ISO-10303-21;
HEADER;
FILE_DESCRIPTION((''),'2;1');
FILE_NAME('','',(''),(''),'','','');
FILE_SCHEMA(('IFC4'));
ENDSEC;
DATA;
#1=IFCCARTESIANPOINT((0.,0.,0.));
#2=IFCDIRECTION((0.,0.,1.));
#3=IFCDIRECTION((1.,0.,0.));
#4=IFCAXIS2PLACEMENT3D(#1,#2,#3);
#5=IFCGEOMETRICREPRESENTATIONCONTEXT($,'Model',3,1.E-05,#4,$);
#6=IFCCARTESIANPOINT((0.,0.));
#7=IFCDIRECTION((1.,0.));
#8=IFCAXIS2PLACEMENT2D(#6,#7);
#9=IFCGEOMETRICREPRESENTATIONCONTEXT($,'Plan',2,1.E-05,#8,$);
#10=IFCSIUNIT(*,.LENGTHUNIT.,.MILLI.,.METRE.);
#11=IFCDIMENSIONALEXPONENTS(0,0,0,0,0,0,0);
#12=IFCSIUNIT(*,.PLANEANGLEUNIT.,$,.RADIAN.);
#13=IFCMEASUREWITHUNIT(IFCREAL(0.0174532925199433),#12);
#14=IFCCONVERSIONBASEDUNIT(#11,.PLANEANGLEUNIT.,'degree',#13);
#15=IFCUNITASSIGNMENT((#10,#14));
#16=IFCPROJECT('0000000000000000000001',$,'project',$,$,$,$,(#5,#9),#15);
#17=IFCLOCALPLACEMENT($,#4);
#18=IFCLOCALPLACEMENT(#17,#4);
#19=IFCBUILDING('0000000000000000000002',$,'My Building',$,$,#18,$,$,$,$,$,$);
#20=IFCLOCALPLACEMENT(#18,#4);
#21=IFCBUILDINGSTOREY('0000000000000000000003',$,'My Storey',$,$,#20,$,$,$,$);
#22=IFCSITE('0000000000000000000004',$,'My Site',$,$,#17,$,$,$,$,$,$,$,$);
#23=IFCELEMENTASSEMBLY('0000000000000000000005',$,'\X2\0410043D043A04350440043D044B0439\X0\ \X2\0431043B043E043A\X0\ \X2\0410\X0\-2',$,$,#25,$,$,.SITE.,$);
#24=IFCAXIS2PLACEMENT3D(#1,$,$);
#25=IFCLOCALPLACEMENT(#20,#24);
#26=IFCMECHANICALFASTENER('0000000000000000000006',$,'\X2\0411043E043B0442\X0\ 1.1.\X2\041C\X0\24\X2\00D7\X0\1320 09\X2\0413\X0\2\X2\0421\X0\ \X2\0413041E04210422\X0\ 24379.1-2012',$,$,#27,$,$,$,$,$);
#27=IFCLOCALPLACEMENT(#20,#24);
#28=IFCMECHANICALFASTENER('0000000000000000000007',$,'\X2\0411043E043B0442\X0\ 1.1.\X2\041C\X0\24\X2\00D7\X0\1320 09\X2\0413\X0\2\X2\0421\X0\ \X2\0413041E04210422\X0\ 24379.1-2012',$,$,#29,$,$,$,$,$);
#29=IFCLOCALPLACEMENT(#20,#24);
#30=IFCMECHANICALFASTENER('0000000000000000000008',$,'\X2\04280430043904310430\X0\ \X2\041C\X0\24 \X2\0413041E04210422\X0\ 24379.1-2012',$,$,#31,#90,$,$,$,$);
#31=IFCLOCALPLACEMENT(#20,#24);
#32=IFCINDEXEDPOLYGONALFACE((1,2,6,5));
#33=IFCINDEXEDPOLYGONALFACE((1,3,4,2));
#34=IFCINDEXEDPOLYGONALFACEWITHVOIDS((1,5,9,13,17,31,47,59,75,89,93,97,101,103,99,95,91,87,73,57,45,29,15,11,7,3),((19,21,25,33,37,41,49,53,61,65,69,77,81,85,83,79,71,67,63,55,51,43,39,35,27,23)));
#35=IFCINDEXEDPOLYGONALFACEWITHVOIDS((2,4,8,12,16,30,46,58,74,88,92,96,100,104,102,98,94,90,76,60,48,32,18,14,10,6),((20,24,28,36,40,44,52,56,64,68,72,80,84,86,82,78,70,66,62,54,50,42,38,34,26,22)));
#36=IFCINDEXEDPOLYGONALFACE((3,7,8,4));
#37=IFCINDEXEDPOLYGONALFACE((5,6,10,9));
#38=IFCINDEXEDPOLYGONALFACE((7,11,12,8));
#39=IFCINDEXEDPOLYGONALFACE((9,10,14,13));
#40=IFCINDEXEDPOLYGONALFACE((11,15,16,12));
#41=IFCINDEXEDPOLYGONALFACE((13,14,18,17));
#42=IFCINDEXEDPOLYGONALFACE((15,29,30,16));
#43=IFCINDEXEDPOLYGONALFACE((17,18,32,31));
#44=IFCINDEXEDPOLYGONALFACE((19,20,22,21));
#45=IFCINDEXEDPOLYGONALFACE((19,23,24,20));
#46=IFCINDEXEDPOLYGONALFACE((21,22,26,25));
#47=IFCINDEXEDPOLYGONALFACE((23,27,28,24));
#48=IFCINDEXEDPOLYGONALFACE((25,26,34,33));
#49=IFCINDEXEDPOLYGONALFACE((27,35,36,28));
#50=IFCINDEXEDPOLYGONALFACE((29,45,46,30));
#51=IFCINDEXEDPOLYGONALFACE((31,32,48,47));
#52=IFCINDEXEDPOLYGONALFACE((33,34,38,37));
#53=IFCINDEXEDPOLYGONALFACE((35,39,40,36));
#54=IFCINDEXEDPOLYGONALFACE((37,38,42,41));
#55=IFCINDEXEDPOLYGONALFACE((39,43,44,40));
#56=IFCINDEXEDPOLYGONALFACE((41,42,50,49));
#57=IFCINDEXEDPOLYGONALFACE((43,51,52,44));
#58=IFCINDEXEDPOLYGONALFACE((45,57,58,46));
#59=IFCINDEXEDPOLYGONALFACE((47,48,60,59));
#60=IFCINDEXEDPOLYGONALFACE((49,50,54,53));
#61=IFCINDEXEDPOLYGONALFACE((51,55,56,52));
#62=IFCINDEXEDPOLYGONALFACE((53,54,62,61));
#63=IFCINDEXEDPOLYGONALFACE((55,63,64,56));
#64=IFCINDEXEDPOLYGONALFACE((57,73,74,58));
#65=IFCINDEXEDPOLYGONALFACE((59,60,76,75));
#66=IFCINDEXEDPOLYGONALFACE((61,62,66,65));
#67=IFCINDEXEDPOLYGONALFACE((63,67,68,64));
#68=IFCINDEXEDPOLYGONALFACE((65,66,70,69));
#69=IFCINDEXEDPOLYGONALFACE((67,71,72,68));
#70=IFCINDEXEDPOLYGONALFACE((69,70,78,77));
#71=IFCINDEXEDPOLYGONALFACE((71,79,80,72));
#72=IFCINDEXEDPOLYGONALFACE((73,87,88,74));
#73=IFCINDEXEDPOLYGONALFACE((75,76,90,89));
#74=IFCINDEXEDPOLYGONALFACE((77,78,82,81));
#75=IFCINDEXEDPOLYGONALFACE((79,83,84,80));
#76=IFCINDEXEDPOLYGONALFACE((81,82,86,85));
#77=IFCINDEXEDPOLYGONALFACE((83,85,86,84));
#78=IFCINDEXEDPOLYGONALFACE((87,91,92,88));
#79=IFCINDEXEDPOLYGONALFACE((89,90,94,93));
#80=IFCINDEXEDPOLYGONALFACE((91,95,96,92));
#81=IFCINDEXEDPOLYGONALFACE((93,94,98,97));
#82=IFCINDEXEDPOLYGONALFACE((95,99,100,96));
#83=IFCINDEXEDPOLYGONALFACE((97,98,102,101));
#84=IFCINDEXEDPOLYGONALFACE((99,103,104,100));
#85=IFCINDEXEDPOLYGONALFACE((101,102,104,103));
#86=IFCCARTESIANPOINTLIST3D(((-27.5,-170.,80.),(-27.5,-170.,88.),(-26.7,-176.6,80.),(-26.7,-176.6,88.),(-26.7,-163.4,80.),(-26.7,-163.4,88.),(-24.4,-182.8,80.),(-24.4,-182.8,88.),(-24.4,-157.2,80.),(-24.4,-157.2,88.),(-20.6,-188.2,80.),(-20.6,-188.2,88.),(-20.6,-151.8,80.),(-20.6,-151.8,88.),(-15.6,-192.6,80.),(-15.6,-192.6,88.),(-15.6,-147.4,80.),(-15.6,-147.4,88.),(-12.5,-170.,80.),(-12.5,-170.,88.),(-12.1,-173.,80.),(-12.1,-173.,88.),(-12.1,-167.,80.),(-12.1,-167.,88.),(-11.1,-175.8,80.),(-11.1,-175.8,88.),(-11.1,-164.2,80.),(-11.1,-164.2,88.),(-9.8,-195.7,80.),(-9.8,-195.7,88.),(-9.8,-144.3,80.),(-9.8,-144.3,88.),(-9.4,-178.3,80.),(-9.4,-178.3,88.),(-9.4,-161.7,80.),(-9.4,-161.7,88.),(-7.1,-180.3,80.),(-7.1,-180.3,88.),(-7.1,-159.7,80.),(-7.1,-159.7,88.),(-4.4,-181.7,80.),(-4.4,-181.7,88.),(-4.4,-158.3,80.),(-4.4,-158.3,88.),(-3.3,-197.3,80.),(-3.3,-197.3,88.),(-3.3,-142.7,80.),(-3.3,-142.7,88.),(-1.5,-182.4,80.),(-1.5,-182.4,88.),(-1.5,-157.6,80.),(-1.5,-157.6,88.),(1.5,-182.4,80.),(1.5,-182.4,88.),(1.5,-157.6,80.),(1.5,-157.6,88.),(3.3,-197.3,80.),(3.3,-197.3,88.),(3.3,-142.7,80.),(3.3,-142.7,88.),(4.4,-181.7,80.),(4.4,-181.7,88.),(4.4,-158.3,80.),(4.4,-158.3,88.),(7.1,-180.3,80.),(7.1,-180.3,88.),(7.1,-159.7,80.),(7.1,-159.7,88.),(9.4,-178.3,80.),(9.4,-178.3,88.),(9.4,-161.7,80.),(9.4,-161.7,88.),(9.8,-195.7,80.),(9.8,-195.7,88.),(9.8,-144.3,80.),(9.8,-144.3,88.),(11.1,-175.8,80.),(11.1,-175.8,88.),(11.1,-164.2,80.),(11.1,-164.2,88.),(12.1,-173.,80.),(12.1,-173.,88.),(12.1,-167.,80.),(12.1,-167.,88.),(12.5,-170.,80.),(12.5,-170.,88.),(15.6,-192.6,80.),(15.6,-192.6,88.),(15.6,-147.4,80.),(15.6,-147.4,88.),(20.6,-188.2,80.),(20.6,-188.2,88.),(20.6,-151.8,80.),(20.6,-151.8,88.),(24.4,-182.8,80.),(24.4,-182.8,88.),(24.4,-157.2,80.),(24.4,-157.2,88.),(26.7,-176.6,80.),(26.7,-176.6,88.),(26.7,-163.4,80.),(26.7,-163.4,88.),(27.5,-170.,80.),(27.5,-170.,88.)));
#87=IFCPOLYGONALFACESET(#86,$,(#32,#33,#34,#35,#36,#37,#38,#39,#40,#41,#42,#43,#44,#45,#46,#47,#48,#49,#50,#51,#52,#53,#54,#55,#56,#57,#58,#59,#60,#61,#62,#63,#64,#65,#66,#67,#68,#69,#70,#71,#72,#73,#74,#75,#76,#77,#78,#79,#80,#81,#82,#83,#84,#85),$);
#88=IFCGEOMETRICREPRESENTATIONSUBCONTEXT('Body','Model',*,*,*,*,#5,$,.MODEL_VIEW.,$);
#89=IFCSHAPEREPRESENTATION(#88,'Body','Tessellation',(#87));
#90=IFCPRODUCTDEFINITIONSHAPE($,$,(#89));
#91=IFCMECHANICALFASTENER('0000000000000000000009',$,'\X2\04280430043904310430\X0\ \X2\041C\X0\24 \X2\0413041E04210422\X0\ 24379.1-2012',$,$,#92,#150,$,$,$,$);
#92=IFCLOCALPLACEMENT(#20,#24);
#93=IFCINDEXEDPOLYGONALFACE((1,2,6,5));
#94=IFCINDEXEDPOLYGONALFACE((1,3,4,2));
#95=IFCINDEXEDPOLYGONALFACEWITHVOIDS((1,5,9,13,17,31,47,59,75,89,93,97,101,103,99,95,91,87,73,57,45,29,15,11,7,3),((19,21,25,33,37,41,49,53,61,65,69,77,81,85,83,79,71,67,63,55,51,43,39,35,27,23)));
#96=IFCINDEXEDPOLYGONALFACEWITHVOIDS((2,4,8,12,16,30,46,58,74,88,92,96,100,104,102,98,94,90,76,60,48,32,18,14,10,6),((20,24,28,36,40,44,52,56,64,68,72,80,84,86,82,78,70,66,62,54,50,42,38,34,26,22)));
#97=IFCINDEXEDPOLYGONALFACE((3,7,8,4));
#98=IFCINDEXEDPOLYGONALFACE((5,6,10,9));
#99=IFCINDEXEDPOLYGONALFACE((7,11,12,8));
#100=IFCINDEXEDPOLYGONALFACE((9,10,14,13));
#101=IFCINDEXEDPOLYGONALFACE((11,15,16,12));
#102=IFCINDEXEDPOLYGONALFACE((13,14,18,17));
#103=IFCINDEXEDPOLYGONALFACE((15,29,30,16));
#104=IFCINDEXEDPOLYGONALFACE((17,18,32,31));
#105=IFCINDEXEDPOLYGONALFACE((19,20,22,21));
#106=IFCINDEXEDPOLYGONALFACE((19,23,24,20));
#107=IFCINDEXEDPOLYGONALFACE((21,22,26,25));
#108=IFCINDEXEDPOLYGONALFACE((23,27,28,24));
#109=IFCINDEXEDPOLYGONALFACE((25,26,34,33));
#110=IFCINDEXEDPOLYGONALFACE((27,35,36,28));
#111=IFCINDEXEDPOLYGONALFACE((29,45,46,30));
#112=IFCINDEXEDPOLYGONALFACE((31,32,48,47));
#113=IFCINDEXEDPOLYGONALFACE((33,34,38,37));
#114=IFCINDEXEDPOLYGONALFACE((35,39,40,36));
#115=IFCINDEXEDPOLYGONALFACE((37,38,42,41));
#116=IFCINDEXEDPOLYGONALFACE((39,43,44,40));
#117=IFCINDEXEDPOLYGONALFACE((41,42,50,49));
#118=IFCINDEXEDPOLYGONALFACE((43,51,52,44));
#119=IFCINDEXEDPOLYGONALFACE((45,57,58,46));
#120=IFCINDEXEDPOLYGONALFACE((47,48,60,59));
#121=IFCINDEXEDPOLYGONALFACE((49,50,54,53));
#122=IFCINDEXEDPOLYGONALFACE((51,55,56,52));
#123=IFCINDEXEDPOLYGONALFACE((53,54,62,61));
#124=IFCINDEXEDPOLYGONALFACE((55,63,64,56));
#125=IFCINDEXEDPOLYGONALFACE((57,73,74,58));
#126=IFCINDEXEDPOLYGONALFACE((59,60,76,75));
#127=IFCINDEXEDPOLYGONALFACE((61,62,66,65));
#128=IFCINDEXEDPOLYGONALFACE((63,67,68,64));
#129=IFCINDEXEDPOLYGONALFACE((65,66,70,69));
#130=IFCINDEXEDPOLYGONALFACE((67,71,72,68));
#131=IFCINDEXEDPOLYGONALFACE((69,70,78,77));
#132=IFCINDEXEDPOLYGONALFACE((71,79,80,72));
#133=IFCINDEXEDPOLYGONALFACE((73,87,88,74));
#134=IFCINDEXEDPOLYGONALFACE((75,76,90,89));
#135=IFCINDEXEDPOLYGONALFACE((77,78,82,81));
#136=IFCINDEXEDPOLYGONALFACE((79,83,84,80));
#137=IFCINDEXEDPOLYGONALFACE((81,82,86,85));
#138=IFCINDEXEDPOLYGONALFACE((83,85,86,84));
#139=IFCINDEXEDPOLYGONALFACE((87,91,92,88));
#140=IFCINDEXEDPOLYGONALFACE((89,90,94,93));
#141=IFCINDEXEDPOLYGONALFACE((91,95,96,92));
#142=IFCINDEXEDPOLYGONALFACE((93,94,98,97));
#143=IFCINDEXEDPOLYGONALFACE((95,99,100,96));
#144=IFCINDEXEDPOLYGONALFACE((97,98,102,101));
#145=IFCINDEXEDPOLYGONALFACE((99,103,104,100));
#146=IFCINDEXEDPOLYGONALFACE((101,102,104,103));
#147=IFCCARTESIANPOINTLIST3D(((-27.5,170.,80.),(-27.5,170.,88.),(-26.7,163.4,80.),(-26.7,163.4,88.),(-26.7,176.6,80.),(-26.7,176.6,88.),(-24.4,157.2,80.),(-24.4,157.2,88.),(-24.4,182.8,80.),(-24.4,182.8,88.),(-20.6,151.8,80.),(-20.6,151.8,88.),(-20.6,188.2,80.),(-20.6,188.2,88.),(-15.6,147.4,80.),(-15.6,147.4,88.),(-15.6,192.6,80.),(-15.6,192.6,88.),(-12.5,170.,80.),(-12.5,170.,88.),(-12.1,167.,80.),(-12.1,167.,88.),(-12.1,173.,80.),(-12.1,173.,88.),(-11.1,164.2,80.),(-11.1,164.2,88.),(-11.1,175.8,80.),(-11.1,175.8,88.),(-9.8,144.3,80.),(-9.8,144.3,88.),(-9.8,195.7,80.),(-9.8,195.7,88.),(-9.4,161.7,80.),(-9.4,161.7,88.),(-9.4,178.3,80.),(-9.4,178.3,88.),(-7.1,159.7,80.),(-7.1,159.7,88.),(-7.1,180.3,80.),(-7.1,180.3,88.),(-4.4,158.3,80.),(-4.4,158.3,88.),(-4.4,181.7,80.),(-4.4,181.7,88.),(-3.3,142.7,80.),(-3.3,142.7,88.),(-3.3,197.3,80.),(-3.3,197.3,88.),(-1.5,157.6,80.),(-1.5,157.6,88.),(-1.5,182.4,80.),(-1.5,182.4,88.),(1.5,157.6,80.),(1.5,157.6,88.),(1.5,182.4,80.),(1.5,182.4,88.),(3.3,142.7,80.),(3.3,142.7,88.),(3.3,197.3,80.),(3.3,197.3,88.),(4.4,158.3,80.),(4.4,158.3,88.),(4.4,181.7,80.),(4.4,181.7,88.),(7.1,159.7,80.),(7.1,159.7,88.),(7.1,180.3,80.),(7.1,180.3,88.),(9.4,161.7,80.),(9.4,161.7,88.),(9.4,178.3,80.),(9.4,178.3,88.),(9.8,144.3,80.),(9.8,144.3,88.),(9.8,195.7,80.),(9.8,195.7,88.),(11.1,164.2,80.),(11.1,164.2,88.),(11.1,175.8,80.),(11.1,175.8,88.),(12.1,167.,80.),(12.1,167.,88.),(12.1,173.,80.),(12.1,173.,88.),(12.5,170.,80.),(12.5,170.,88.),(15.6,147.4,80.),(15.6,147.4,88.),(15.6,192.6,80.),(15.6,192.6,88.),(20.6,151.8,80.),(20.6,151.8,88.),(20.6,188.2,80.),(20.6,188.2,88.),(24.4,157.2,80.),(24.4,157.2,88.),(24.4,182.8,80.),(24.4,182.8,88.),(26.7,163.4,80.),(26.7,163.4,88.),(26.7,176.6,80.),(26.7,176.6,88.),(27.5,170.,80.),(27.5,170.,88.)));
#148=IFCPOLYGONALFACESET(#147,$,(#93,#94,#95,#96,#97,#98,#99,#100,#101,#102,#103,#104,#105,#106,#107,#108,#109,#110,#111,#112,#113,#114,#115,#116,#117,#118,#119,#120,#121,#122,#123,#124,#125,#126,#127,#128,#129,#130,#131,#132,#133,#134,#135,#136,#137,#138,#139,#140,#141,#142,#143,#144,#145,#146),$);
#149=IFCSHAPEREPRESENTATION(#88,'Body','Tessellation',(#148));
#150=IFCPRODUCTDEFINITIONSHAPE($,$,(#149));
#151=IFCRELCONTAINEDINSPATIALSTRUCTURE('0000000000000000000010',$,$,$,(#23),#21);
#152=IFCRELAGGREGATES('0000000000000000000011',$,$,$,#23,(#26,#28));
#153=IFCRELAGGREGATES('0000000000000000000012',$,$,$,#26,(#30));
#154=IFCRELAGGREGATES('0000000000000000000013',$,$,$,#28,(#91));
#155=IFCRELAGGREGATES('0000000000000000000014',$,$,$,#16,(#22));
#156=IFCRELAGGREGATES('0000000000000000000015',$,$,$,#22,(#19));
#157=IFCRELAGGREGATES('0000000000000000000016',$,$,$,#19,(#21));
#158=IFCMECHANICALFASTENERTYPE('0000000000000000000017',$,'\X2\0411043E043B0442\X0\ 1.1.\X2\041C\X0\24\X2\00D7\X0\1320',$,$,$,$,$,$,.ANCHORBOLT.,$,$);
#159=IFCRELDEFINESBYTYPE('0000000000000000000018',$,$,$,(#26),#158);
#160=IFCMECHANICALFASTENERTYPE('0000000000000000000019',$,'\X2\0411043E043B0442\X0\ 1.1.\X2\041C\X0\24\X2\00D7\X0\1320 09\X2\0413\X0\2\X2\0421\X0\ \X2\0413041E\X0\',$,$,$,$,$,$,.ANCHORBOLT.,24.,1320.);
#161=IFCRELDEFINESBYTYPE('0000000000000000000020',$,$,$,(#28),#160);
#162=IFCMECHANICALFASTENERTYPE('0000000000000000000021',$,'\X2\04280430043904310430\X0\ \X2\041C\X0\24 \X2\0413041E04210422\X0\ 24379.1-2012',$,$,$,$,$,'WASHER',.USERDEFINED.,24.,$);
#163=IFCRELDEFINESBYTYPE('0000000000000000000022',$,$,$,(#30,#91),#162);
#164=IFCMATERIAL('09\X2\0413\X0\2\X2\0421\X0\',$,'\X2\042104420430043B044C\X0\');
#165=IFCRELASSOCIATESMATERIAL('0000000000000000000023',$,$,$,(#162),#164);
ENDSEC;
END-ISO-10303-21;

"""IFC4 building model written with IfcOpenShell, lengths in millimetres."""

from ifc_helpers import new_model, entity, si_unit, converted_unit, frame, origin_with_axes, origin_2d_with_axis, place, context, subcontext, project, spatial, polyline, outline, extrude, source, transform, mapped, material, type_object, type_shapes, element, aggregate, save


model = new_model("IFC4")

# Units and contexts
model_context = context("Model", 3, precision=1e-05, world=origin_with_axes())
plan_context = context("Plan", 2, precision=1e-05, world=origin_2d_with_axis())
body_context = subcontext(model_context, "Body", "Model", "MODEL_VIEW")
ifc_project = project(units=[si_unit("LENGTHUNIT", "METRE", prefix="MILLI"), converted_unit("PLANEANGLEUNIT", "degree", entity("IfcReal", 0.0174532925199433), si_unit("PLANEANGLEUNIT", "RADIAN"), dimensions=[0, 0, 0, 0, 0, 0, 0])], contexts=[model_context, plan_context])

# Site, building, storey
site_placement = place(None, origin_with_axes())
site = spatial("IfcSite", under=ifc_project, at=site_placement, Name="My Site")
building_placement = place(site_placement, origin_with_axes())
building = spatial("IfcBuilding", under=site, at=building_placement, Name="My Building")
storey_placement = place(building_placement, origin_with_axes())
storey = spatial("IfcBuildingStorey", under=building, at=storey_placement, Name="My Storey")

# Shared definitions
placement = place(storey_placement, origin_with_axes())

# Element assembly, mechanical fasteners
assembly_1 = element("IfcElementAssembly", 1, at=placement, inside=storey, Name="Анкерный блок А-2", AssemblyPlace="SITE")
mechanical_fastener_type_1 = type_object("IfcMechanicalFastenerType", Name="Болт 1.1.М24×1320", PredefinedType="ANCHORBOLT")
mechanical_fastener_1_placement = place(placement, frame((0.0, -170.0, 0.0), z_axis=(0.0, 0.0, 1.0), x_axis=(1.0, 0.0, 0.0)))
mechanical_fastener_1 = element("IfcMechanicalFastener", 2, at=mechanical_fastener_1_placement, type_object=mechanical_fastener_type_1, Name="Болт 1.1.М24×1320 09Г2С ГОСТ 24379.1-2012")
ifc_material_1 = material(Name="09Г2С", Category="Сталь")
mechanical_fastener_type_2 = type_object("IfcMechanicalFastenerType", Name="Болт 1.1.М24×1320 09Г2С ГО", NominalDiameter=24.0, NominalLength=1320.0, PredefinedType="ANCHORBOLT")
mechanical_fastener_2_placement = place(placement, frame((0.0, 170.0, 0.0), z_axis=(0.0, 0.0, 1.0), x_axis=(-1.0, 0.0, 0.0)))
mechanical_fastener_2 = element("IfcMechanicalFastener", 3, at=mechanical_fastener_2_placement, type_object=mechanical_fastener_type_2, Name="Болт 1.1.М24×1320 09Г2С ГОСТ 24379.1-2012")
aggregate(assembly_1, [mechanical_fastener_1, mechanical_fastener_2])

# Mechanical fasteners
mechanical_fastener_type_3 = type_object("IfcMechanicalFastenerType", Name="Шайба М24 ГОСТ 24379.1-2012", ElementType="WASHER", NominalDiameter=24.0, PredefinedType="USERDEFINED", material=ifc_material_1)
shared_shape_1 = source(origin_with_axes(), body_context, "Body", "SweptSolid", [
    extrude(outline(polyline([(27.5, 0.0), (26.7, 6.6), (24.4, 12.8), (20.6, 18.2), (15.6, 22.6), (9.8, 25.7), (3.3, 27.3), (-3.3, 27.3), (-9.8, 25.7), (-15.6, 22.6), (-20.6, 18.2), (-24.4, 12.8), (-26.7, 6.6), (-27.5, 0.0), (-26.7, -6.6), (-24.4, -12.8), (-20.6, -18.2), (-15.6, -22.6), (-9.8, -25.7), (-3.3, -27.3), (3.3, -27.3), (9.8, -25.7), (15.6, -22.6), (20.6, -18.2), (24.4, -12.8), (26.7, -6.6), (27.5, 0.0)]), holes=[polyline([(-4.4, -11.7), (-7.1, -10.3), (-9.4, -8.3), (-11.1, -5.8), (-12.1, -3.0), (-12.5, 0.0), (-12.1, 3.0), (-11.1, 5.8), (-9.4, 8.3), (-7.1, 10.3), (-4.4, 11.7), (-1.5, 12.4), (1.5, 12.4), (4.4, 11.7), (7.1, 10.3), (9.4, 8.3), (11.1, 5.8), (12.1, 3.0), (12.5, 0.0), (12.1, -3.0), (11.1, -5.8), (9.4, -8.3), (7.1, -10.3), (4.4, -11.7), (1.5, -12.4), (-1.5, -12.4), (-4.4, -11.7)])]), frame((0.0, 0.0, 0.0), z_axis=(0.0, 0.0, 1.0), x_axis=(0.120537, -0.992709, 0.0)), (0.0, 0.0, 1.0), 8.0),
])
type_shapes(mechanical_fastener_type_3, [shared_shape_1])
mechanical_fastener_3_placement = place(mechanical_fastener_1_placement, frame((0.0, 0.0, 80.0), z_axis=(0.0, 0.0, 1.0), x_axis=(1.0, 0.0, 0.0)))
mechanical_fastener_3 = element("IfcMechanicalFastener", 4, at=mechanical_fastener_3_placement, type_object=mechanical_fastener_type_3, Name="Шайба М24 ГОСТ 24379.1-2012", context=body_context, shape_type="MappedRepresentation", body=[
    mapped(shared_shape_1, transform((0.0, 0.0, 0.0), x_axis=(1.0, 0.0, 0.0), y_axis=(0.0, 1.0, 0.0), z_axis=(0.0, 0.0, 1.0), scale=1.0)),
])
aggregate(mechanical_fastener_1, [mechanical_fastener_3])
mechanical_fastener_4_placement = place(mechanical_fastener_2_placement, frame((0.0, 0.0, 80.0), z_axis=(0.0, 0.0, 1.0), x_axis=(1.0, 0.0, 0.0)))
mechanical_fastener_4 = element("IfcMechanicalFastener", 5, at=mechanical_fastener_4_placement, type_object=mechanical_fastener_type_3, Name="Шайба М24 ГОСТ 24379.1-2012", context=body_context, shape_type="MappedRepresentation", body=[
    mapped(shared_shape_1, transform((0.0, 0.0, 0.0), x_axis=(1.0, 0.0, 0.0), y_axis=(0.0, 1.0, 0.0), z_axis=(0.0, 0.0, 1.0), scale=1.0)),
])
aggregate(mechanical_fastener_2, [mechanical_fastener_4])

save(model, "model.ifc")
